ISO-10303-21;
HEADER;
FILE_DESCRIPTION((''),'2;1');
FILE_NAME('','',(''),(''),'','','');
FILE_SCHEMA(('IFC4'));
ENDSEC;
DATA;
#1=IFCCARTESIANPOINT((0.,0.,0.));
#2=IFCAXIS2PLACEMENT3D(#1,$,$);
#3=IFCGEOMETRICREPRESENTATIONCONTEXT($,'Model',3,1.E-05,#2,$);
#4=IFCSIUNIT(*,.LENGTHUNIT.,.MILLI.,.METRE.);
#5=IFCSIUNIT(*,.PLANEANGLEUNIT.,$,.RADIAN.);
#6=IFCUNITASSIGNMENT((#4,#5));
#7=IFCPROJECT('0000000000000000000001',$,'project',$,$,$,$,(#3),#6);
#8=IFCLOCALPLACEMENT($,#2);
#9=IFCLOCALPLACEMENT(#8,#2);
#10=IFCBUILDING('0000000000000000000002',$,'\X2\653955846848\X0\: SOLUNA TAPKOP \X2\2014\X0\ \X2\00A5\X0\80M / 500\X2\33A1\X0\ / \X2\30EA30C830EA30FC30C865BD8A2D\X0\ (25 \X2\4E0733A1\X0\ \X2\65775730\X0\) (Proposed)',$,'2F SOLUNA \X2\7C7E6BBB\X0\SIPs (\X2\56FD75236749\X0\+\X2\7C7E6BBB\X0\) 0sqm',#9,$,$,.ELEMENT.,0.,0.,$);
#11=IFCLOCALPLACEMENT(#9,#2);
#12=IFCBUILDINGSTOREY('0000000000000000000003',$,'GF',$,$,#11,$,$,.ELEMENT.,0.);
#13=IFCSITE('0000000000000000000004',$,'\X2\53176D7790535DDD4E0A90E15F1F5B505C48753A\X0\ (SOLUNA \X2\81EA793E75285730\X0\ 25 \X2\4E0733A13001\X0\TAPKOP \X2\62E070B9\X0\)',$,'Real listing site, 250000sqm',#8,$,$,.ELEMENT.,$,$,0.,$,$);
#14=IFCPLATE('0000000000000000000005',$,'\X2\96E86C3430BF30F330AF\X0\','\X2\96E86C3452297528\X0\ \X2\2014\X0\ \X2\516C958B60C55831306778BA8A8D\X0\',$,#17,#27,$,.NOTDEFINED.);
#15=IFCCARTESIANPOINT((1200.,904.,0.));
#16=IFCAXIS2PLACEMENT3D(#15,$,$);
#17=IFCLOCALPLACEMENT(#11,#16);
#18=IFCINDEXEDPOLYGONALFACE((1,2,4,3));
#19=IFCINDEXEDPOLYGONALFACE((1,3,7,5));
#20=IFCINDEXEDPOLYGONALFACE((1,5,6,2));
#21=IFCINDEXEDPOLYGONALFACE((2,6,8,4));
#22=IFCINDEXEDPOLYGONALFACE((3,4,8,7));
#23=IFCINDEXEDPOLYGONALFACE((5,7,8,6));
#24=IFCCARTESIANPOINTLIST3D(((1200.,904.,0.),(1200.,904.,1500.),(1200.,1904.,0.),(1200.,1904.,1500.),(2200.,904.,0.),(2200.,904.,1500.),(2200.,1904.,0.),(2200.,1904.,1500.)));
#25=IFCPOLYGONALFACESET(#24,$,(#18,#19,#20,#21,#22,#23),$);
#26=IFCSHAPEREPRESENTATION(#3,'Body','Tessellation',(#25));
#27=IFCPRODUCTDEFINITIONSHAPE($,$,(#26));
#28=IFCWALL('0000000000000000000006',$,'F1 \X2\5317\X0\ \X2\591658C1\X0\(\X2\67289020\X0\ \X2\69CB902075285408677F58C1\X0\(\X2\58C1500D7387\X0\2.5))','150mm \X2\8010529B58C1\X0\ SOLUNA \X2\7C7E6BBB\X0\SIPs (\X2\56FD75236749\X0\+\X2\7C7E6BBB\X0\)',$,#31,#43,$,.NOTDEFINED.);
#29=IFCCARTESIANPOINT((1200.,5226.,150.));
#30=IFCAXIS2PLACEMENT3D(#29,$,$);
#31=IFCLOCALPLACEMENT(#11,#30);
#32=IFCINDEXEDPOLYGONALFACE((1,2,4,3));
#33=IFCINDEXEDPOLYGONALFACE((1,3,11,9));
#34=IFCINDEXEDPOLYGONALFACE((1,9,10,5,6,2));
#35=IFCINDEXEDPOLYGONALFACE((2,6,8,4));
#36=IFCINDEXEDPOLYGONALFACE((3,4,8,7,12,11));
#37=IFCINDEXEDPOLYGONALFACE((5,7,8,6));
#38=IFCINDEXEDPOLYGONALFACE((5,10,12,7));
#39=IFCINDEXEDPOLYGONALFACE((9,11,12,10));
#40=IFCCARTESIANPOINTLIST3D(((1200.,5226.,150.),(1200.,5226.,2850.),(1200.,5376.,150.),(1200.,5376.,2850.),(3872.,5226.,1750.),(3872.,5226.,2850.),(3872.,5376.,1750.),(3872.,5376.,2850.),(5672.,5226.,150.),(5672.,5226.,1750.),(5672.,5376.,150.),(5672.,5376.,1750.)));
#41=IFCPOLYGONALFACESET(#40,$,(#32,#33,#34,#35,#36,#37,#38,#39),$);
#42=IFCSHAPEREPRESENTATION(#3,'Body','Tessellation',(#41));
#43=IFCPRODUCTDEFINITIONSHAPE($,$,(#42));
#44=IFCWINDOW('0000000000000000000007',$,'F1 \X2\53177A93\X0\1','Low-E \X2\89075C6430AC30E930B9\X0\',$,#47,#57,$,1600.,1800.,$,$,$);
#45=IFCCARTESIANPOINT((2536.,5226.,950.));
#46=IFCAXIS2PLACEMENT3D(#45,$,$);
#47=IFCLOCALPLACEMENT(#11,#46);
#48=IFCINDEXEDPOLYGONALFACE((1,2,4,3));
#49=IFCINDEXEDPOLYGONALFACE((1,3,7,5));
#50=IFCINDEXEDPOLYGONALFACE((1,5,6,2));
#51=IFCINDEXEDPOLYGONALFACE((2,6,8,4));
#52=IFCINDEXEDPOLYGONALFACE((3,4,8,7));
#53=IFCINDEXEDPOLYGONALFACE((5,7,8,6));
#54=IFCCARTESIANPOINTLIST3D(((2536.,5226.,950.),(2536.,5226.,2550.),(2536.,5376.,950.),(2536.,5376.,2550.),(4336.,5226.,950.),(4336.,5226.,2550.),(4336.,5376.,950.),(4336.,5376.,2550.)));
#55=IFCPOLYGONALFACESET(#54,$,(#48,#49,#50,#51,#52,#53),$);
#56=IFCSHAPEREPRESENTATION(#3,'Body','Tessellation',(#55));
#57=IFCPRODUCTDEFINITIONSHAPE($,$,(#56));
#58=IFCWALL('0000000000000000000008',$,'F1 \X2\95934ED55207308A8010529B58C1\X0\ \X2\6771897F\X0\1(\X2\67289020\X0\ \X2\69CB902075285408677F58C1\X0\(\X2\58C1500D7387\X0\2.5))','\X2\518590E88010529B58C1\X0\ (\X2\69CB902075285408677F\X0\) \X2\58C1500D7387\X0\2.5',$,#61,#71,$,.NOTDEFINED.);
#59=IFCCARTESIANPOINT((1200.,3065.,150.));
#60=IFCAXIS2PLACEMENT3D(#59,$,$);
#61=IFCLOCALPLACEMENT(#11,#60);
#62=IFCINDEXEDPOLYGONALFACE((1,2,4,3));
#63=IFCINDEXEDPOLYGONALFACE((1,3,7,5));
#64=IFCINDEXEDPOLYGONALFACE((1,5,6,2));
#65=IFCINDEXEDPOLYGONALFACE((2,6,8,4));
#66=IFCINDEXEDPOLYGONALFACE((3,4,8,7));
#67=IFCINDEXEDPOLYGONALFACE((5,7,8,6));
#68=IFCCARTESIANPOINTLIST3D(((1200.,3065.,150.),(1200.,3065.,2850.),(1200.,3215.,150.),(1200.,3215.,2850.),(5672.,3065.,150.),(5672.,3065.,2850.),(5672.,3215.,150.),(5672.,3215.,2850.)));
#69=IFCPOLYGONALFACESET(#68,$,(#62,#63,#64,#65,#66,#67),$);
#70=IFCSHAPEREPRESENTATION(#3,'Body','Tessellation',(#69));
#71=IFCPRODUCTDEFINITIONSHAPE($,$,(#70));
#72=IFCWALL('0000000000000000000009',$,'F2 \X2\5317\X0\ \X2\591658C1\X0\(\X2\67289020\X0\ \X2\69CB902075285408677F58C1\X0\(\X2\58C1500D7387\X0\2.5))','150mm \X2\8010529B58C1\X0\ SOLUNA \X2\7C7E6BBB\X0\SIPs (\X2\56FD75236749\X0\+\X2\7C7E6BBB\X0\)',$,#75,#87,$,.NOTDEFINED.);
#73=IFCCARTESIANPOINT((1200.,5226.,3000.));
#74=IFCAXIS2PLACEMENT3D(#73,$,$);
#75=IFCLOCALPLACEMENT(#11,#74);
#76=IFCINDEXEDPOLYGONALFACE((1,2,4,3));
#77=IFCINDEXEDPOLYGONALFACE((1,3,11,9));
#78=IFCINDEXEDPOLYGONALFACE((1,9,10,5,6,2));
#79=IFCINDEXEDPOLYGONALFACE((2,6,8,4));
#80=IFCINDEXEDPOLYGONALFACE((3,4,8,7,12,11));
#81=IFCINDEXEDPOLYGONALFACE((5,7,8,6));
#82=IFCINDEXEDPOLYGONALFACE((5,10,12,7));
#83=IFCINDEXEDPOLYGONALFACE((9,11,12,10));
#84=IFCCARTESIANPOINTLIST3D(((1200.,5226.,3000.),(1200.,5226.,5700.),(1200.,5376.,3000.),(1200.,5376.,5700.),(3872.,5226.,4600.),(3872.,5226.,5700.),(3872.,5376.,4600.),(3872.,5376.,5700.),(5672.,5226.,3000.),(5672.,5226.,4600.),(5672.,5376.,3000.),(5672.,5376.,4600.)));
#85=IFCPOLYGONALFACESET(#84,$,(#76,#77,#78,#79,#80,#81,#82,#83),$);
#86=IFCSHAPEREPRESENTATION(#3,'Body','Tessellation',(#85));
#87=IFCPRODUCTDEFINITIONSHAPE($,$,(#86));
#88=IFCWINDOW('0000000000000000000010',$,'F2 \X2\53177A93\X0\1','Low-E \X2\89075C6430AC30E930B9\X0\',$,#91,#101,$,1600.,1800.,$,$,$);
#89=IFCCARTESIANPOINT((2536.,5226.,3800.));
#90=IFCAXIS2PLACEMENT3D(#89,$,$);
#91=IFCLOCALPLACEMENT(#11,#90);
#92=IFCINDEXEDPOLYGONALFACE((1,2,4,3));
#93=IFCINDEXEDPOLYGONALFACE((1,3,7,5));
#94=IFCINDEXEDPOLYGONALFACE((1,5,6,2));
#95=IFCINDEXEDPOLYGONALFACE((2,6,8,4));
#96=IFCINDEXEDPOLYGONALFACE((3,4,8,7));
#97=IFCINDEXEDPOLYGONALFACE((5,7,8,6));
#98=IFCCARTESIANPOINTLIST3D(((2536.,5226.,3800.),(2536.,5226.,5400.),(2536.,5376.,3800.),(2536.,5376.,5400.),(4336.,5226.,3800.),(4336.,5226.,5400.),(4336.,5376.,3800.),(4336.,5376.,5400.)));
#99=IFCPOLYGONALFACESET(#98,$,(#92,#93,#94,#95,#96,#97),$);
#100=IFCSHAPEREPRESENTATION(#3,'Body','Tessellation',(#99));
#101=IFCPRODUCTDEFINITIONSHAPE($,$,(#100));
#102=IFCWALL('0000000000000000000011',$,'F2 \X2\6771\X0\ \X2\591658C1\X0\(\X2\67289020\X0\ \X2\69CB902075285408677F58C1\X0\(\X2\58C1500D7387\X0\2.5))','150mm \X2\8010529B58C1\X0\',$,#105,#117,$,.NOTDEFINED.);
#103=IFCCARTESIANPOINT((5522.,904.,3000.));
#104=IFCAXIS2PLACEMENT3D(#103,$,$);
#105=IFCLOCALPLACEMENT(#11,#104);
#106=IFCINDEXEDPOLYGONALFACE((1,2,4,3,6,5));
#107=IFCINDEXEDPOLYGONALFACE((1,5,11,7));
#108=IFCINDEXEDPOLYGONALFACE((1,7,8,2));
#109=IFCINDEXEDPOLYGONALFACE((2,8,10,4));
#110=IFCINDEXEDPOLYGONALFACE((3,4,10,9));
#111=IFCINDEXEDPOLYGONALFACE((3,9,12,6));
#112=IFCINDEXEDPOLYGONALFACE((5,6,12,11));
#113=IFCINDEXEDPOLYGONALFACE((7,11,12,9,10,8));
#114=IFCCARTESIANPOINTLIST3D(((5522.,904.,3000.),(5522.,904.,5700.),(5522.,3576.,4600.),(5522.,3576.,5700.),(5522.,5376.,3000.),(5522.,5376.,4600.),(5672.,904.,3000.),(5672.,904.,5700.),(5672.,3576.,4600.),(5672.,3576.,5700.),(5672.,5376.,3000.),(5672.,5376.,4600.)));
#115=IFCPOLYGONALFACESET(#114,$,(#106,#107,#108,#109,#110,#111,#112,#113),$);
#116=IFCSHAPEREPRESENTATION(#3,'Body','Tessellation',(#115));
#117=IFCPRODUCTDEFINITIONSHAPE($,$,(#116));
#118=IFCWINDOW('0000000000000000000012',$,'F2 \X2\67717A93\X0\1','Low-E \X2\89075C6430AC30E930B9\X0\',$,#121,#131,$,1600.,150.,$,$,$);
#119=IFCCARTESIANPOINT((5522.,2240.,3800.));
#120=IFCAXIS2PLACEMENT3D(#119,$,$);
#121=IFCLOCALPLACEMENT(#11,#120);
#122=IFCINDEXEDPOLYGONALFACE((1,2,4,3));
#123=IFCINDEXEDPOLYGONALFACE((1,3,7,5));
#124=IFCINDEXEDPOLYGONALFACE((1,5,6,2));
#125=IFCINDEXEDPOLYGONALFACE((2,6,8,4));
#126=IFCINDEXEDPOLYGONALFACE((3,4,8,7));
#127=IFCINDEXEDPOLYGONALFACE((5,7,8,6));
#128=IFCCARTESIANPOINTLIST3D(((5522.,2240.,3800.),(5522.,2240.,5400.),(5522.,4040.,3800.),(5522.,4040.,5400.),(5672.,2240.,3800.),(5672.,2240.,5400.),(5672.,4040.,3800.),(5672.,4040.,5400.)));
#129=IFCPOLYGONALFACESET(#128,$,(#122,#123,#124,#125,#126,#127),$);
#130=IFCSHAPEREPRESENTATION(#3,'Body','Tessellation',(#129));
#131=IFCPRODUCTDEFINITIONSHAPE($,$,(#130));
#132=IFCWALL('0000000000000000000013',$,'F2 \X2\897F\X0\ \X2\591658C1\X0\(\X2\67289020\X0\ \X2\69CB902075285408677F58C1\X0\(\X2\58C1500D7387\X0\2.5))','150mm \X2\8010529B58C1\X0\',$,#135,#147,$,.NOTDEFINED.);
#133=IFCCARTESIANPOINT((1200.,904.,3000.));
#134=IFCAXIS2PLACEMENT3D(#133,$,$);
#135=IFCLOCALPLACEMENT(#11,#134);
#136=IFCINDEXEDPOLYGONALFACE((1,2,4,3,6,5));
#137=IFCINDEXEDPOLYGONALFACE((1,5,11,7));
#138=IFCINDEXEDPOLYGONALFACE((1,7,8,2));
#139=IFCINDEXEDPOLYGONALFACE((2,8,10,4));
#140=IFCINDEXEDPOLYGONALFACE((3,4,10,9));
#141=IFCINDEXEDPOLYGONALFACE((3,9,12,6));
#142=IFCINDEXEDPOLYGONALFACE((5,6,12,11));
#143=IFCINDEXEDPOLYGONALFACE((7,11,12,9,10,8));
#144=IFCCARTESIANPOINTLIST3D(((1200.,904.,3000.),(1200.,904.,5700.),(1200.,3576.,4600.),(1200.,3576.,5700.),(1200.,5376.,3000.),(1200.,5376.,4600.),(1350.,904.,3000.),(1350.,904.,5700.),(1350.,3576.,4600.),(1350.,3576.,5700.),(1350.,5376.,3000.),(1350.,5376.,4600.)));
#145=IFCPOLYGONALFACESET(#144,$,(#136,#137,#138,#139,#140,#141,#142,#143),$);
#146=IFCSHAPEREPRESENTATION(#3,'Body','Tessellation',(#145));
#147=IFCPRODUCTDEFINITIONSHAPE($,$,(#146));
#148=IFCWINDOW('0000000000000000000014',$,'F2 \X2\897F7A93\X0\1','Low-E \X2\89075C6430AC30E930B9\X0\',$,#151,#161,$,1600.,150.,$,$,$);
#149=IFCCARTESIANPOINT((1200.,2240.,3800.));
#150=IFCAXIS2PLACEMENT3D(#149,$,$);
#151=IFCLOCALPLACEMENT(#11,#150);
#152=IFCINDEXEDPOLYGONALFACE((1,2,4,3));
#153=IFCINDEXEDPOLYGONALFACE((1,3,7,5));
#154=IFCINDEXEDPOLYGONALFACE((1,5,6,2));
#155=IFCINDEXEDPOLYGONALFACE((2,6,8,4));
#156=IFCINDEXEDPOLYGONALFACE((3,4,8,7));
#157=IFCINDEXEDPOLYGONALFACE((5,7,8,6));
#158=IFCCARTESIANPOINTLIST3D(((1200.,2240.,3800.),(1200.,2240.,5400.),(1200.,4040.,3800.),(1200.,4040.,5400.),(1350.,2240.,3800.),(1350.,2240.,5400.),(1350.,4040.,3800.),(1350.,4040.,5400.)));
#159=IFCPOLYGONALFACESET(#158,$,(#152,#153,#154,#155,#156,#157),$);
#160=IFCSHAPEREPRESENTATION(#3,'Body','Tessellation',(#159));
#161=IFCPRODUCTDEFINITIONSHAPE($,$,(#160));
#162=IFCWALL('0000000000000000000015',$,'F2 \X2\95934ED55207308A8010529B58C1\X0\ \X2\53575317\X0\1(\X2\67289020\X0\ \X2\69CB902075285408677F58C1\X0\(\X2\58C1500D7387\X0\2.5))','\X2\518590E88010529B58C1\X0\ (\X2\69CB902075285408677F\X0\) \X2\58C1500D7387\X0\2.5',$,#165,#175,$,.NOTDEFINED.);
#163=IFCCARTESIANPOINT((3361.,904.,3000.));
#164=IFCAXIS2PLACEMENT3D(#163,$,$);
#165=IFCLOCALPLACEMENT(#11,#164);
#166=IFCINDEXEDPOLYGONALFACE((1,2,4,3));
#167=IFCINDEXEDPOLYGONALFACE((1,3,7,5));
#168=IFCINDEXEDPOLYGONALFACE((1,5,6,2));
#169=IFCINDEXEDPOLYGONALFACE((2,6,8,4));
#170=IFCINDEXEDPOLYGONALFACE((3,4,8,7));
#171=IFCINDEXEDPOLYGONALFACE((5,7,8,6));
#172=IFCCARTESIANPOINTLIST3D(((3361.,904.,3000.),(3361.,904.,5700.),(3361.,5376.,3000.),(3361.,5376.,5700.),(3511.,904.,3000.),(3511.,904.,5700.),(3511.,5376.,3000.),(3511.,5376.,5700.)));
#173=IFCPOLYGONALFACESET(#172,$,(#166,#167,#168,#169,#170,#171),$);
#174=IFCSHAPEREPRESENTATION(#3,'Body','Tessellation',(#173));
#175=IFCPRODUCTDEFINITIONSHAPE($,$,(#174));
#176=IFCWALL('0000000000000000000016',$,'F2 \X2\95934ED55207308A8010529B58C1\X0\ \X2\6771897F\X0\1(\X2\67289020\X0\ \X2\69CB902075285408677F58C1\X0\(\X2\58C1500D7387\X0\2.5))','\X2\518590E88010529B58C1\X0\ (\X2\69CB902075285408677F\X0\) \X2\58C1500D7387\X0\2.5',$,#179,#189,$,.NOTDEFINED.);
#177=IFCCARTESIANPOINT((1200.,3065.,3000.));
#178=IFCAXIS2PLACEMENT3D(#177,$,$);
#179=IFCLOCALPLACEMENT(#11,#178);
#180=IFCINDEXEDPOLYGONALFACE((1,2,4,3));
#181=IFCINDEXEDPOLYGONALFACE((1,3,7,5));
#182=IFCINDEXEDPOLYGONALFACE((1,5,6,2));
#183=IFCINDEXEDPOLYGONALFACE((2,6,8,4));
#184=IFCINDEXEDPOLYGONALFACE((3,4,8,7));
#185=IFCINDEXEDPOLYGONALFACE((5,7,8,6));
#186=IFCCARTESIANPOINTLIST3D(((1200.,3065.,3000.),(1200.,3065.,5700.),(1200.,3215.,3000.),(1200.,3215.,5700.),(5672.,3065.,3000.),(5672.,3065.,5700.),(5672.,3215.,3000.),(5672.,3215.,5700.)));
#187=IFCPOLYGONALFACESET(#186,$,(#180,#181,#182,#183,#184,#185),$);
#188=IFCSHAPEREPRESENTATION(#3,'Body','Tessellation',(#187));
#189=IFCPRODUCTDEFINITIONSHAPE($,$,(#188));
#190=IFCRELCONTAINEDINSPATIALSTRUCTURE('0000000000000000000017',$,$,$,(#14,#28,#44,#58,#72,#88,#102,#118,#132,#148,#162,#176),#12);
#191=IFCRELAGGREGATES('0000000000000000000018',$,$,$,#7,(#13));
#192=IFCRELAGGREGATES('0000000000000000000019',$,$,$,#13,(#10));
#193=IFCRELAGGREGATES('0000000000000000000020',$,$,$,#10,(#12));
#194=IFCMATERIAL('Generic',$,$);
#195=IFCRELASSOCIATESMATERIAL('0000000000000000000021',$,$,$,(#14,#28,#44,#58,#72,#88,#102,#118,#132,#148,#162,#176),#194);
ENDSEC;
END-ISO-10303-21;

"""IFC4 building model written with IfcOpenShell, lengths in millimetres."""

from ifc_helpers import new_model, si_unit, frame, frame_2d, origin, place, context, project, spatial, rectangle, extrude, material, element, fill, save


model = new_model("IFC4")

# Units and contexts
model_context = context("Model", 3, precision=1e-05, world=origin())
ifc_project = project(units=[si_unit("LENGTHUNIT", "METRE", prefix="MILLI"), si_unit("PLANEANGLEUNIT", "RADIAN")], contexts=[model_context])

# Site, building, storey
site_placement = place(None, origin())
site = spatial("IfcSite", under=ifc_project, at=site_placement, Name="北海道川上郡弟子屈町 (SOLUNA 自社用地 25 万㎡、TAPKOP 拠点)", ObjectType="Real listing site, 250000sqm", CompositionType="ELEMENT", RefElevation=0.0)
building_placement = place(site_placement, origin())
building = spatial("IfcBuilding", under=site, at=building_placement, Name="改善案: SOLUNA TAPKOP — ¥80M / 500㎡ / リトリート施設 (25 万㎡ 敷地) (Proposed)", ObjectType="2F SOLUNA 籾殻SIPs (国産杉+籾殻) 0sqm", CompositionType="ELEMENT", ElevationOfRefHeight=0.0, ElevationOfTerrain=0.0)
storey_placement = place(building_placement, origin())
storey = spatial("IfcBuildingStorey", under=building, at=storey_placement, Name="GF", CompositionType="ELEMENT", Elevation=0.0)

# Plate
ifc_material_1 = material(Name="Generic")
plate_placement = place(storey_placement, frame((1200.0, 904.0, 0.0)))
element("IfcPlate", 1, at=plate_placement, inside=storey, material=ifc_material_1, Name="雨水タンク", Description="雨水利用 — 公開情報で確認", PredefinedType="NOTDEFINED", context=model_context, shape_type="SweptSolid", body=[
    extrude(rectangle(XDim=1000.0, YDim=1000.0, at=frame_2d((500.0, 500.0))), frame((1200.0, 904.0, 0.0)), (0.0, 0.0, 1.0), 1500.0),
])

# Wall, opening, window
wall_1_placement = place(storey_placement, frame((1200.0, 5226.0, 150.0)))
wall_1 = element("IfcWall", 2, at=wall_1_placement, inside=storey, material=ifc_material_1, Name="F1 北 外壁(木造 構造用合板壁(壁倍率2.5))", Description="150mm 耐力壁 SOLUNA 籾殻SIPs (国産杉+籾殻)", PredefinedType="NOTDEFINED", context=model_context, shape_type="SweptSolid", body=[
    extrude(rectangle(XDim=4472.0, YDim=150.0, at=frame_2d((2236.0, 75.0))), frame((1200.0, 5226.0, 150.0)), (0.0, 0.0, 1.0), 2700.0),
])
opening_1_placement = place(storey_placement, frame((2536.0, 5226.0, 950.0)))
opening_1 = element("IfcOpeningElement", 3, at=opening_1_placement, cuts=wall_1, PredefinedType="NOTDEFINED", context=model_context, shape_type="SweptSolid", body=[
    extrude(rectangle(XDim=1800.0, YDim=150.0, at=frame_2d((900.0, 75.0))), frame((2536.0, 5226.0, 950.0)), (0.0, 0.0, 1.0), 1600.0),
])
window_1_placement = place(storey_placement, frame((2536.0, 5226.0, 950.0)))
window_1 = element("IfcWindow", 4, at=window_1_placement, inside=storey, material=ifc_material_1, Name="F1 北窓1", Description="Low-E 複層ガラス", OverallHeight=1600.0, OverallWidth=1800.0, context=model_context, shape_type="SweptSolid", body=[
    extrude(rectangle(XDim=1800.0, YDim=150.0, at=frame_2d((900.0, 75.0))), frame((2536.0, 5226.0, 950.0)), (0.0, 0.0, 1.0), 1600.0),
])
fill(opening_1, window_1)

# Wall
wall_2_placement = place(storey_placement, frame((1200.0, 3065.0, 150.0)))
element("IfcWall", 5, at=wall_2_placement, inside=storey, material=ifc_material_1, Name="F1 間仕切り耐力壁 東西1(木造 構造用合板壁(壁倍率2.5))", Description="内部耐力壁 (構造用合板) 壁倍率2.5", PredefinedType="NOTDEFINED", context=model_context, shape_type="SweptSolid", body=[
    extrude(rectangle(XDim=4472.0, YDim=150.0, at=frame_2d((2236.0, 75.0))), frame((1200.0, 3065.0, 150.0)), (0.0, 0.0, 1.0), 2700.0),
])

# Walls, openings, windows
wall_3_placement = place(storey_placement, frame((1200.0, 5226.0, 3000.0)))
wall_3 = element("IfcWall", 6, at=wall_3_placement, inside=storey, material=ifc_material_1, Name="F2 北 外壁(木造 構造用合板壁(壁倍率2.5))", Description="150mm 耐力壁 SOLUNA 籾殻SIPs (国産杉+籾殻)", PredefinedType="NOTDEFINED", context=model_context, shape_type="SweptSolid", body=[
    extrude(rectangle(XDim=4472.0, YDim=150.0, at=frame_2d((2236.0, 75.0))), frame((1200.0, 5226.0, 3000.0)), (0.0, 0.0, 1.0), 2700.0),
])
opening_2_placement = place(storey_placement, frame((2536.0, 5226.0, 3800.0)))
opening_2 = element("IfcOpeningElement", 7, at=opening_2_placement, cuts=wall_3, PredefinedType="NOTDEFINED", context=model_context, shape_type="SweptSolid", body=[
    extrude(rectangle(XDim=1800.0, YDim=150.0, at=frame_2d((900.0, 75.0))), frame((2536.0, 5226.0, 3800.0)), (0.0, 0.0, 1.0), 1600.0),
])
window_2_placement = place(storey_placement, frame((2536.0, 5226.0, 3800.0)))
window_2 = element("IfcWindow", 8, at=window_2_placement, inside=storey, material=ifc_material_1, Name="F2 北窓1", Description="Low-E 複層ガラス", OverallHeight=1600.0, OverallWidth=1800.0, context=model_context, shape_type="SweptSolid", body=[
    extrude(rectangle(XDim=1800.0, YDim=150.0, at=frame_2d((900.0, 75.0))), frame((2536.0, 5226.0, 3800.0)), (0.0, 0.0, 1.0), 1600.0),
])
fill(opening_2, window_2)
wall_4_placement = place(storey_placement, frame((5522.0, 904.0, 3000.0)))
wall_4 = element("IfcWall", 9, at=wall_4_placement, inside=storey, material=ifc_material_1, Name="F2 東 外壁(木造 構造用合板壁(壁倍率2.5))", Description="150mm 耐力壁", PredefinedType="NOTDEFINED", context=model_context, shape_type="SweptSolid", body=[
    extrude(rectangle(XDim=150.0, YDim=4472.0, at=frame_2d((75.0, 2236.0))), frame((5522.0, 904.0, 3000.0)), (0.0, 0.0, 1.0), 2700.0),
])
opening_3_placement = place(storey_placement, frame((5522.0, 2240.0, 3800.0)))
opening_3 = element("IfcOpeningElement", 10, at=opening_3_placement, cuts=wall_4, PredefinedType="NOTDEFINED", context=model_context, shape_type="SweptSolid", body=[
    extrude(rectangle(XDim=150.0, YDim=1800.0, at=frame_2d((75.0, 900.0))), frame((5522.0, 2240.0, 3800.0)), (0.0, 0.0, 1.0), 1600.0),
])
window_3_placement = place(storey_placement, frame((5522.0, 2240.0, 3800.0)))
window_3 = element("IfcWindow", 11, at=window_3_placement, inside=storey, material=ifc_material_1, Name="F2 東窓1", Description="Low-E 複層ガラス", OverallHeight=1600.0, OverallWidth=150.0, context=model_context, shape_type="SweptSolid", body=[
    extrude(rectangle(XDim=150.0, YDim=1800.0, at=frame_2d((75.0, 900.0))), frame((5522.0, 2240.0, 3800.0)), (0.0, 0.0, 1.0), 1600.0),
])
fill(opening_3, window_3)
wall_5_placement = place(storey_placement, frame((1200.0, 904.0, 3000.0)))
wall_5 = element("IfcWall", 12, at=wall_5_placement, inside=storey, material=ifc_material_1, Name="F2 西 外壁(木造 構造用合板壁(壁倍率2.5))", Description="150mm 耐力壁", PredefinedType="NOTDEFINED", context=model_context, shape_type="SweptSolid", body=[
    extrude(rectangle(XDim=150.0, YDim=4472.0, at=frame_2d((75.0, 2236.0))), frame((1200.0, 904.0, 3000.0)), (0.0, 0.0, 1.0), 2700.0),
])
opening_4_placement = place(storey_placement, frame((1200.0, 2240.0, 3800.0)))
opening_4 = element("IfcOpeningElement", 13, at=opening_4_placement, cuts=wall_5, PredefinedType="NOTDEFINED", context=model_context, shape_type="SweptSolid", body=[
    extrude(rectangle(XDim=150.0, YDim=1800.0, at=frame_2d((75.0, 900.0))), frame((1200.0, 2240.0, 3800.0)), (0.0, 0.0, 1.0), 1600.0),
])
window_4_placement = place(storey_placement, frame((1200.0, 2240.0, 3800.0)))
window_4 = element("IfcWindow", 14, at=window_4_placement, inside=storey, material=ifc_material_1, Name="F2 西窓1", Description="Low-E 複層ガラス", OverallHeight=1600.0, OverallWidth=150.0, context=model_context, shape_type="SweptSolid", body=[
    extrude(rectangle(XDim=150.0, YDim=1800.0, at=frame_2d((75.0, 900.0))), frame((1200.0, 2240.0, 3800.0)), (0.0, 0.0, 1.0), 1600.0),
])
fill(opening_4, window_4)

# Walls
wall_6_placement = place(storey_placement, frame((3361.0, 904.0, 3000.0)))
element("IfcWall", 15, at=wall_6_placement, inside=storey, material=ifc_material_1, Name="F2 間仕切り耐力壁 南北1(木造 構造用合板壁(壁倍率2.5))", Description="内部耐力壁 (構造用合板) 壁倍率2.5", PredefinedType="NOTDEFINED", context=model_context, shape_type="SweptSolid", body=[
    extrude(rectangle(XDim=150.0, YDim=4472.0, at=frame_2d((75.0, 2236.0))), frame((3361.0, 904.0, 3000.0)), (0.0, 0.0, 1.0), 2700.0),
])
wall_7_placement = place(storey_placement, frame((1200.0, 3065.0, 3000.0)))
element("IfcWall", 16, at=wall_7_placement, inside=storey, material=ifc_material_1, Name="F2 間仕切り耐力壁 東西1(木造 構造用合板壁(壁倍率2.5))", Description="内部耐力壁 (構造用合板) 壁倍率2.5", PredefinedType="NOTDEFINED", context=model_context, shape_type="SweptSolid", body=[
    extrude(rectangle(XDim=4472.0, YDim=150.0, at=frame_2d((2236.0, 75.0))), frame((1200.0, 3065.0, 3000.0)), (0.0, 0.0, 1.0), 2700.0),
])

save(model, "model.ifc")
